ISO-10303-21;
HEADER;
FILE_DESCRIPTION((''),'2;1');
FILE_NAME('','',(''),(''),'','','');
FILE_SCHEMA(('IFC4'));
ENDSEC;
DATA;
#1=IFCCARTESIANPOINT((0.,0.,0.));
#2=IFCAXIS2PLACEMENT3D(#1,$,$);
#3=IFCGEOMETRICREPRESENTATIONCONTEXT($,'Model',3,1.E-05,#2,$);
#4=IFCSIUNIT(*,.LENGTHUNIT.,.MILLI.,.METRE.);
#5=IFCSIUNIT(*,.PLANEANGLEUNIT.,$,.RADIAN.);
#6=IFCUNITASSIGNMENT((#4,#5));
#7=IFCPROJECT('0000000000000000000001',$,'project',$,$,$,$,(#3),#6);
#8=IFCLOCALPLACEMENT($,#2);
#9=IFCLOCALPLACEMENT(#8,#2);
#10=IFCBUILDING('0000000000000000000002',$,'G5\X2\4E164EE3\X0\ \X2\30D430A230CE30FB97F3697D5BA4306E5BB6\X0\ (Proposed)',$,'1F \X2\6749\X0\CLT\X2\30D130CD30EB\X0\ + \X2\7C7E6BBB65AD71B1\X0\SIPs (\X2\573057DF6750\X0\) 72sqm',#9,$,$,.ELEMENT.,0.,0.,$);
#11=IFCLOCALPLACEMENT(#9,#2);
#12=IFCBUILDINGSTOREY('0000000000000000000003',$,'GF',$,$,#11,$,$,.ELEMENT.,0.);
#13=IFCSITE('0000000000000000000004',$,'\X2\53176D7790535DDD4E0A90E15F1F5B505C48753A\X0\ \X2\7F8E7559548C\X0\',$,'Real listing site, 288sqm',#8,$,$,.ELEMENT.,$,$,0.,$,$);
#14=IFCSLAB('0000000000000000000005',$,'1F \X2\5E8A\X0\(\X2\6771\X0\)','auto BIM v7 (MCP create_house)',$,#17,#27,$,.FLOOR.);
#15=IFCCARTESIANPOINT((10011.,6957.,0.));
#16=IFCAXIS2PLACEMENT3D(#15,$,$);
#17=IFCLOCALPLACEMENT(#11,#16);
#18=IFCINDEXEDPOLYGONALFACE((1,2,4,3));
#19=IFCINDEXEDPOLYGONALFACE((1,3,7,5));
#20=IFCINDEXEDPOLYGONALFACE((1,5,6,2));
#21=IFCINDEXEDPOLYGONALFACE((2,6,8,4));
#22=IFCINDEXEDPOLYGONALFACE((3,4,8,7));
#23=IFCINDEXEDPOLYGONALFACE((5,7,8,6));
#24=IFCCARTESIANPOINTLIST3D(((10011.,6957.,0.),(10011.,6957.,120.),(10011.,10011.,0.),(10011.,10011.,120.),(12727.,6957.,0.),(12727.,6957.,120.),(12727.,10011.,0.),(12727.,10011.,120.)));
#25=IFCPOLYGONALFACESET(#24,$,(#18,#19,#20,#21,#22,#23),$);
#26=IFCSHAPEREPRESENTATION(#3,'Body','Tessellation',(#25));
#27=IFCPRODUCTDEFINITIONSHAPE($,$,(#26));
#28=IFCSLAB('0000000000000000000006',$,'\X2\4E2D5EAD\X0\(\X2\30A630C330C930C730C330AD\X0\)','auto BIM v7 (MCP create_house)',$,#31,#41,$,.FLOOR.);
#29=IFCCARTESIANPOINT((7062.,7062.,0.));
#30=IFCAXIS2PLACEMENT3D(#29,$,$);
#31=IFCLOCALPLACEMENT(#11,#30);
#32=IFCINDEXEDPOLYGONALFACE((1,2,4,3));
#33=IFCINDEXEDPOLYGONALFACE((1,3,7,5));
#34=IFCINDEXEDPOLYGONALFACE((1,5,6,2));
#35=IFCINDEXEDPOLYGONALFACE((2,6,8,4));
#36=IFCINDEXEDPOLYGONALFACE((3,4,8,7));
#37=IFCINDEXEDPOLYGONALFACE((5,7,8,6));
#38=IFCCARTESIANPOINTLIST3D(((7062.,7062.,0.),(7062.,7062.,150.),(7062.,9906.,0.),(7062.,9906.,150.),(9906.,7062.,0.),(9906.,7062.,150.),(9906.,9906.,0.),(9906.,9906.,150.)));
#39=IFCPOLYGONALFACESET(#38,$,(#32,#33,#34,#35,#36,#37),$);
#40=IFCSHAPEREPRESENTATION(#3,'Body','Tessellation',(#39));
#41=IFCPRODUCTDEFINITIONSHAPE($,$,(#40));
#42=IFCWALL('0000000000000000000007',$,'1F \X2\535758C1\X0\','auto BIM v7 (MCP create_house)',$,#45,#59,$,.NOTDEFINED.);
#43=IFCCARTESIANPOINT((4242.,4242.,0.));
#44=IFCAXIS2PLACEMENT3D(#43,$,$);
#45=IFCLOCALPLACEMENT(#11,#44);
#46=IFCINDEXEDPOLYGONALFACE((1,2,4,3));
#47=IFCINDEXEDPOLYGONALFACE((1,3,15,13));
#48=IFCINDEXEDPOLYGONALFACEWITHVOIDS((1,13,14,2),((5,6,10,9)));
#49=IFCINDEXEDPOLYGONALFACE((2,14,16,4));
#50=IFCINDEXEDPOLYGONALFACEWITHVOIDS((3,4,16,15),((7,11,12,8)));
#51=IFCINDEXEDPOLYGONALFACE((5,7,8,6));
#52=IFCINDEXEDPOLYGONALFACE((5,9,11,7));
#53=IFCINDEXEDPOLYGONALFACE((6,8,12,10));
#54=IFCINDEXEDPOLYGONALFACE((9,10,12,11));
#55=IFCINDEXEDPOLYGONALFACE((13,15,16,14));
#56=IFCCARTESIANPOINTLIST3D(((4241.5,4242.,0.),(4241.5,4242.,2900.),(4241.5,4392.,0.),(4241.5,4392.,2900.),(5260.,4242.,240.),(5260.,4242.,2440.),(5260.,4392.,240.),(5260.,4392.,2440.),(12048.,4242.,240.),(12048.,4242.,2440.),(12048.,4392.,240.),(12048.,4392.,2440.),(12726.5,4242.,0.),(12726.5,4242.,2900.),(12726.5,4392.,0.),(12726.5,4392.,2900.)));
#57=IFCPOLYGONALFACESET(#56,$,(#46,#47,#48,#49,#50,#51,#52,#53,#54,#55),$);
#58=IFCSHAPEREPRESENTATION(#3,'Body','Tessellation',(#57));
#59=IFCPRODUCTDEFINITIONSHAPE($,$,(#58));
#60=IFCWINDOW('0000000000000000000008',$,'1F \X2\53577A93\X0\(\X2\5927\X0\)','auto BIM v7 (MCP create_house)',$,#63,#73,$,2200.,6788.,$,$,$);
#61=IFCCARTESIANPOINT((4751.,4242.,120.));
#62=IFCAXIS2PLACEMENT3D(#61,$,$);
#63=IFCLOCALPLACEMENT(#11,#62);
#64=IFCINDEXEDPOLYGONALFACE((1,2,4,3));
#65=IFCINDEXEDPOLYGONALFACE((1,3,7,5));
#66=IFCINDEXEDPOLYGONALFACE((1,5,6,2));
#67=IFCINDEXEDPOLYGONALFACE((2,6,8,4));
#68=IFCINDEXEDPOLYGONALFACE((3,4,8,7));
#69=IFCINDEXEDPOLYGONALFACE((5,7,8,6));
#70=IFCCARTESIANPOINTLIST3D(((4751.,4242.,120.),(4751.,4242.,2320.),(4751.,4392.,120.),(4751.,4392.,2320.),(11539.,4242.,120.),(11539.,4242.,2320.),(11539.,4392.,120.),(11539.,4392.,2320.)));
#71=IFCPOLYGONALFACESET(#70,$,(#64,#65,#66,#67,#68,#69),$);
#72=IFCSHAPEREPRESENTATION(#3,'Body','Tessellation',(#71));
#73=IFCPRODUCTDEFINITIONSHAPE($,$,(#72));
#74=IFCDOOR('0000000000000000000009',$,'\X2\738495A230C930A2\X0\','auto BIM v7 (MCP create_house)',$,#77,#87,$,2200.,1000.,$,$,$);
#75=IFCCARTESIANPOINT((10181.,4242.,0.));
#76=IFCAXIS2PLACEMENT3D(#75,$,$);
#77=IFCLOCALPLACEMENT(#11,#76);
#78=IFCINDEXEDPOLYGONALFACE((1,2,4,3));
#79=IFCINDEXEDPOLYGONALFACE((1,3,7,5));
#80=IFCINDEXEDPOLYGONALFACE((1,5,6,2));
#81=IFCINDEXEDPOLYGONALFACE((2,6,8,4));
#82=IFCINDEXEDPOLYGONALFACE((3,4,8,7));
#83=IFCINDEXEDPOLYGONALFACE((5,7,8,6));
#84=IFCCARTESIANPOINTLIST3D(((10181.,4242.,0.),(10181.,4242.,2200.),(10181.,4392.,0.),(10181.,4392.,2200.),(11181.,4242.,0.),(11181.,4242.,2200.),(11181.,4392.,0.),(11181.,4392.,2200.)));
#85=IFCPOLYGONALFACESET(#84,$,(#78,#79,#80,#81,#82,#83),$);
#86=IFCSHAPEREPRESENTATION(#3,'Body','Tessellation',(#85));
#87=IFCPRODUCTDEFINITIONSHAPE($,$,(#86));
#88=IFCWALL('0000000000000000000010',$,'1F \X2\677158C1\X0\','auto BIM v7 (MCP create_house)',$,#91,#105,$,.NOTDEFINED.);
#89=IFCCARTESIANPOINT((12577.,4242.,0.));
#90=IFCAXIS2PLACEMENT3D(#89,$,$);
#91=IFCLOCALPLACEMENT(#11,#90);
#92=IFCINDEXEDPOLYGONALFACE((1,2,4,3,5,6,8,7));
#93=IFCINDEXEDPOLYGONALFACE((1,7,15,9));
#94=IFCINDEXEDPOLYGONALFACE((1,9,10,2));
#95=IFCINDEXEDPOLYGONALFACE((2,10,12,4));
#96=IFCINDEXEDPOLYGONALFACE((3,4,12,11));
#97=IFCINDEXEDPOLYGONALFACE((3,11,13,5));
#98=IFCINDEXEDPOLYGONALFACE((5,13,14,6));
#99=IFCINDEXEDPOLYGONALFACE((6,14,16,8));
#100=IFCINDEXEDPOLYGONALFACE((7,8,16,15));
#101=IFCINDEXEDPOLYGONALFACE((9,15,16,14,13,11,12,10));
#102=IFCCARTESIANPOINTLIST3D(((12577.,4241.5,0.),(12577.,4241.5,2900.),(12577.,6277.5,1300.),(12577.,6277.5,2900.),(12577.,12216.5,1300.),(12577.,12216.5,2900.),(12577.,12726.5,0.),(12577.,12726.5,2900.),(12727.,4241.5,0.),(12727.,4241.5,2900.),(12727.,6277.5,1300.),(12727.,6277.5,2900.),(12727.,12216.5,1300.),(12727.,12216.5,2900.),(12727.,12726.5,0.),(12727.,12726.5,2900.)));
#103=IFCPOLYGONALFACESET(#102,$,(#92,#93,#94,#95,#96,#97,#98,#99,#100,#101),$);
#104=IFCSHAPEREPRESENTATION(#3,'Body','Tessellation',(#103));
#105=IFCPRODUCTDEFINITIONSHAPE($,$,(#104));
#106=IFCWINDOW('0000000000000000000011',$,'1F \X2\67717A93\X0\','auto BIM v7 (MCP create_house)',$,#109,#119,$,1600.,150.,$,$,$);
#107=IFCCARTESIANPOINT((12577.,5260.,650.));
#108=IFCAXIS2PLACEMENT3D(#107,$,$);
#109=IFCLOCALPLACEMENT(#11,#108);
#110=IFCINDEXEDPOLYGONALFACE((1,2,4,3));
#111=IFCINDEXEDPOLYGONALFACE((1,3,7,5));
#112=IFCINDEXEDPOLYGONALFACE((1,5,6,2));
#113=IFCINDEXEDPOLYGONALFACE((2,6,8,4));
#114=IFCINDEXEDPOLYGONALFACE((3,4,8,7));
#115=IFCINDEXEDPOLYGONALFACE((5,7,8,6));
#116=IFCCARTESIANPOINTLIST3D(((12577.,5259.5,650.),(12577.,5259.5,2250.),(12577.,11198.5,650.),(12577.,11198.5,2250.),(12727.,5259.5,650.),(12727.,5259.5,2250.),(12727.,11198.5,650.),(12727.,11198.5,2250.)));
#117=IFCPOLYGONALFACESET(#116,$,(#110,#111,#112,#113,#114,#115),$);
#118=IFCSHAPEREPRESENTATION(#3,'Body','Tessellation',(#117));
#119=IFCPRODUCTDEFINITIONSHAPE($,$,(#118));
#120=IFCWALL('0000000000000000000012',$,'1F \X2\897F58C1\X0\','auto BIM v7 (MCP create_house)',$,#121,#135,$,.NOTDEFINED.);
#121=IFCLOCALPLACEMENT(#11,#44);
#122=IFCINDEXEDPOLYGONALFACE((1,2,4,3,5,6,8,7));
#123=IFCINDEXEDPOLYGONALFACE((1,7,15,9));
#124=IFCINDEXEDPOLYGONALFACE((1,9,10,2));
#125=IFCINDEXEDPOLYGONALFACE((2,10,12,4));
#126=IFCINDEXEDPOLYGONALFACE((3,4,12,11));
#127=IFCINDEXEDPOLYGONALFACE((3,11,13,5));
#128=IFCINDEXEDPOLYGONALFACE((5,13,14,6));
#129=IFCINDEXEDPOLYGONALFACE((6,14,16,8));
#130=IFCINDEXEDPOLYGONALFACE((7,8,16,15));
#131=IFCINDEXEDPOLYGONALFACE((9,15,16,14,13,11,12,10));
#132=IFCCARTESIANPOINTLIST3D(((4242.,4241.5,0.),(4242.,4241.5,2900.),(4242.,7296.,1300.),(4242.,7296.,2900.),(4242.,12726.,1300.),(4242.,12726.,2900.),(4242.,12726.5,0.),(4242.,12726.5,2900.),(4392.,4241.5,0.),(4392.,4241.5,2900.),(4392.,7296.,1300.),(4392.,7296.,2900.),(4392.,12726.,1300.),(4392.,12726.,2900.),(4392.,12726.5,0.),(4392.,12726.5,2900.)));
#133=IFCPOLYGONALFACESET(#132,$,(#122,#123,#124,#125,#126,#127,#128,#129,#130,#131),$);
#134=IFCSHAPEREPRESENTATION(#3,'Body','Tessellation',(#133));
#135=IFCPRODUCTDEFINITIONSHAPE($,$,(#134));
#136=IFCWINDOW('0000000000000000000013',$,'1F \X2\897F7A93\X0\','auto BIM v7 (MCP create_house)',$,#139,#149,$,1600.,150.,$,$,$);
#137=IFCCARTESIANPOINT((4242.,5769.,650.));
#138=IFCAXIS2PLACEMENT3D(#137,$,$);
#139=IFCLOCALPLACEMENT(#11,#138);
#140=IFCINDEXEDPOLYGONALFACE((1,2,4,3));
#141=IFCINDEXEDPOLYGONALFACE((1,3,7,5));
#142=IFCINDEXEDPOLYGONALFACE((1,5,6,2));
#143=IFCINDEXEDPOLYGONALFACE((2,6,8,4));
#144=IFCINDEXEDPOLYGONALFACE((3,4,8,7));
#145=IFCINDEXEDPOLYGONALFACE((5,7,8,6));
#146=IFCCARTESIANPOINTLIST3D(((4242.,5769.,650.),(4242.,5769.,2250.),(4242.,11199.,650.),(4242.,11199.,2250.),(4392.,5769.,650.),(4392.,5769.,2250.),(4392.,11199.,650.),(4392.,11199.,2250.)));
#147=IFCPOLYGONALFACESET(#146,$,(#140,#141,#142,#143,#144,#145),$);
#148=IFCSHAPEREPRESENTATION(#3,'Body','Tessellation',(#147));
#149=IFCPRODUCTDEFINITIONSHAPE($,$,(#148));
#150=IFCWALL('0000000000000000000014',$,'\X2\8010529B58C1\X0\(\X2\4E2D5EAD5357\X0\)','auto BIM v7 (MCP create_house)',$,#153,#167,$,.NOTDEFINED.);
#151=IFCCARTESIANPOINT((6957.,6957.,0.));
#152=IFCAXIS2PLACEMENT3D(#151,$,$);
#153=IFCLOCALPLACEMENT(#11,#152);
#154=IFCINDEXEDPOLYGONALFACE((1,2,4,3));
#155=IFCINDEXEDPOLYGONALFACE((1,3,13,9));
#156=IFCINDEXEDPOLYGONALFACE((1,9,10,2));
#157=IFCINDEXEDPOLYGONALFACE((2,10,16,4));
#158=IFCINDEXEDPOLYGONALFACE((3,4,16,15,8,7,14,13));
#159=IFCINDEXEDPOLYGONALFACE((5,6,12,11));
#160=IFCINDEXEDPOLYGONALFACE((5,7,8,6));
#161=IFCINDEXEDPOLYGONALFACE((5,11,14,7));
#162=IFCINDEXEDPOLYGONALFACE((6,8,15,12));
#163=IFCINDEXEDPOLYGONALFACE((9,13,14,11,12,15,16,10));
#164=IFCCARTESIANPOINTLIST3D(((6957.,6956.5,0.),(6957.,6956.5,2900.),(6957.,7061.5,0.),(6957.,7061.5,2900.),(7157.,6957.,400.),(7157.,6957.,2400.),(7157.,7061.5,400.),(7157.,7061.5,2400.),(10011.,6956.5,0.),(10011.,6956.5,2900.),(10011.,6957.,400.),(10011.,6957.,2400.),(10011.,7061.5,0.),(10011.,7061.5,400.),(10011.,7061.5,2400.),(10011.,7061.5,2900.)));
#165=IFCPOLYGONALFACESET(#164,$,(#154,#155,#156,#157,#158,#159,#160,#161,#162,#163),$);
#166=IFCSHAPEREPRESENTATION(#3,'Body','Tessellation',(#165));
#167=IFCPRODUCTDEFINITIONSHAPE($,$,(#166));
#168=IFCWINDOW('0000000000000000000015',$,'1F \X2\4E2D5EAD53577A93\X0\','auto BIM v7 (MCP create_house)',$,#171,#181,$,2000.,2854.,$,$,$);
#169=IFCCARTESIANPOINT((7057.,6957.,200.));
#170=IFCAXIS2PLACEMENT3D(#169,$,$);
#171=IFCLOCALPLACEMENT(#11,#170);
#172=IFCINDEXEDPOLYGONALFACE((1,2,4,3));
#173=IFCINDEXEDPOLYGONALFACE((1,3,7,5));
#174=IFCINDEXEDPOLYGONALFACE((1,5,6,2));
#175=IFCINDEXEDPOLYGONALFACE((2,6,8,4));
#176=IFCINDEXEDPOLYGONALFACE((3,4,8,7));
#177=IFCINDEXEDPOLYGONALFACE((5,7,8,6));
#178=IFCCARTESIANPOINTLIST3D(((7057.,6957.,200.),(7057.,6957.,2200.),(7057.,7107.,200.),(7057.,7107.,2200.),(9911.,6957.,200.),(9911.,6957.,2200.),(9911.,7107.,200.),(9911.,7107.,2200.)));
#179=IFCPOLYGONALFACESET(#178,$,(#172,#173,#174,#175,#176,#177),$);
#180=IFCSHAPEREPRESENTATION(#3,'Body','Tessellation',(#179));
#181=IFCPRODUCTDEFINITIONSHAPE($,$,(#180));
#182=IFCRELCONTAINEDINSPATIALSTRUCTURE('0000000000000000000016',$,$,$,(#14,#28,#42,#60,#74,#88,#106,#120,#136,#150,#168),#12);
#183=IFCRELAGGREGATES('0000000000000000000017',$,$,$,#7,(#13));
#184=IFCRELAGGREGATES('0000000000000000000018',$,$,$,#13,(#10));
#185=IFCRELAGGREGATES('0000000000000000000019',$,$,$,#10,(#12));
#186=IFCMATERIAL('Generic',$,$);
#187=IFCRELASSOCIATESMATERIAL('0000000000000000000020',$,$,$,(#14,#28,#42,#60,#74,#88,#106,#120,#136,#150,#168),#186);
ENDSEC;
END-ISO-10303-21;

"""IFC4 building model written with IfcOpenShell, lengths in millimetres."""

from ifc_helpers import new_model, si_unit, frame, frame_2d, origin, place, context, project, spatial, rectangle, extrude, material, element, fill, save


model = new_model("IFC4")

# Units and contexts
model_context = context("Model", 3, precision=1e-05, world=origin())
ifc_project = project(units=[si_unit("LENGTHUNIT", "METRE", prefix="MILLI"), si_unit("PLANEANGLEUNIT", "RADIAN")], contexts=[model_context])

# Site, building, storey
site_placement = place(None, origin())
site = spatial("IfcSite", under=ifc_project, at=site_placement, Name="北海道川上郡弟子屈町 美留和", ObjectType="Real listing site, 288sqm", CompositionType="ELEMENT", RefElevation=0.0)
building_placement = place(site_placement, origin())
building = spatial("IfcBuilding", under=site, at=building_placement, Name="G5世代 ピアノ・音楽室の家 (Proposed)", ObjectType="1F 杉CLTパネル + 籾殻断熱SIPs (地域材) 72sqm", CompositionType="ELEMENT", ElevationOfRefHeight=0.0, ElevationOfTerrain=0.0)
storey_placement = place(building_placement, origin())
storey = spatial("IfcBuildingStorey", under=building, at=storey_placement, Name="GF", CompositionType="ELEMENT", Elevation=0.0)

# Slabs
ifc_material = material(Name="Generic")
slab_1_placement = place(storey_placement, frame((10011.0, 6957.0, 0.0)))
element("IfcSlab", 1, at=slab_1_placement, inside=storey, material=ifc_material, Name="1F 床(東)", Description="auto BIM v7 (MCP create_house)", PredefinedType="FLOOR", context=model_context, shape_type="SweptSolid", body=[
    extrude(rectangle(XDim=2716.0, YDim=3054.0, at=frame_2d((1358.0, 1527.0))), frame((10011.0, 6957.0, 0.0)), (0.0, 0.0, 1.0), 120.0),
])
slab_2_placement = place(storey_placement, frame((7062.0, 7062.0, 0.0)))
element("IfcSlab", 2, at=slab_2_placement, inside=storey, material=ifc_material, Name="中庭(ウッドデッキ)", Description="auto BIM v7 (MCP create_house)", PredefinedType="FLOOR", context=model_context, shape_type="SweptSolid", body=[
    extrude(rectangle(XDim=2844.0, YDim=2844.0, at=frame_2d((1422.0, 1422.0))), frame((7062.0, 7062.0, 0.0)), (0.0, 0.0, 1.0), 150.0),
])

# Wall, openings, window, door
wall_1_placement = place(storey_placement, frame((4242.0, 4242.0, 0.0)))
wall_1 = element("IfcWall", 3, at=wall_1_placement, inside=storey, material=ifc_material, Name="1F 南壁", Description="auto BIM v7 (MCP create_house)", PredefinedType="NOTDEFINED", context=model_context, shape_type="SweptSolid", body=[
    extrude(rectangle(XDim=8485.0, YDim=150.0, at=frame_2d((4242.0, 75.0))), frame((4242.0, 4242.0, 0.0)), (0.0, 0.0, 1.0), 2900.0),
])
opening_1_placement = place(storey_placement, frame((4751.0, 4242.0, 120.0)))
opening_1 = element("IfcOpeningElement", 4, at=opening_1_placement, cuts=wall_1, PredefinedType="NOTDEFINED", context=model_context, shape_type="SweptSolid", body=[
    extrude(rectangle(XDim=6788.0, YDim=150.0, at=frame_2d((3394.0, 75.0))), frame((4751.0, 4242.0, 120.0)), (0.0, 0.0, 1.0), 2200.0),
])
opening_2_placement = place(storey_placement, frame((10181.0, 4242.0, 0.0)))
opening_2 = element("IfcOpeningElement", 5, at=opening_2_placement, cuts=wall_1, PredefinedType="NOTDEFINED", context=model_context, shape_type="SweptSolid", body=[
    extrude(rectangle(XDim=1000.0, YDim=150.0, at=frame_2d((500.0, 75.0))), frame((10181.0, 4242.0, 0.0)), (0.0, 0.0, 1.0), 2200.0),
])
window_1_placement = place(storey_placement, frame((4751.0, 4242.0, 120.0)))
window_1 = element("IfcWindow", 6, at=window_1_placement, inside=storey, material=ifc_material, Name="1F 南窓(大)", Description="auto BIM v7 (MCP create_house)", OverallHeight=2200.0, OverallWidth=6788.0, context=model_context, shape_type="SweptSolid", body=[
    extrude(rectangle(XDim=6788.0, YDim=150.0, at=frame_2d((3394.0, 75.0))), frame((4751.0, 4242.0, 120.0)), (0.0, 0.0, 1.0), 2200.0),
])
fill(opening_1, window_1)
door_placement = place(storey_placement, frame((10181.0, 4242.0, 0.0)))
door = element("IfcDoor", 7, at=door_placement, inside=storey, material=ifc_material, Name="玄関ドア", Description="auto BIM v7 (MCP create_house)", OverallHeight=2200.0, OverallWidth=1000.0, context=model_context, shape_type="SweptSolid", body=[
    extrude(rectangle(XDim=1000.0, YDim=150.0, at=frame_2d((500.0, 75.0))), frame((10181.0, 4242.0, 0.0)), (0.0, 0.0, 1.0), 2200.0),
])
fill(opening_2, door)

# Walls, openings, windows
wall_2_placement = place(storey_placement, frame((12577.0, 4242.0, 0.0)))
wall_2 = element("IfcWall", 8, at=wall_2_placement, inside=storey, material=ifc_material, Name="1F 東壁", Description="auto BIM v7 (MCP create_house)", PredefinedType="NOTDEFINED", context=model_context, shape_type="SweptSolid", body=[
    extrude(rectangle(XDim=150.0, YDim=8485.0, at=frame_2d((75.0, 4242.0))), frame((12577.0, 4242.0, 0.0)), (0.0, 0.0, 1.0), 2900.0),
])
opening_3_placement = place(storey_placement, frame((12577.0, 5260.0, 650.0)))
opening_3 = element("IfcOpeningElement", 9, at=opening_3_placement, cuts=wall_2, PredefinedType="NOTDEFINED", context=model_context, shape_type="SweptSolid", body=[
    extrude(rectangle(XDim=150.0, YDim=5939.0, at=frame_2d((75.0, 2969.0))), frame((12577.0, 5260.0, 650.0)), (0.0, 0.0, 1.0), 1600.0),
])
window_2_placement = place(storey_placement, frame((12577.0, 5260.0, 650.0)))
window_2 = element("IfcWindow", 10, at=window_2_placement, inside=storey, material=ifc_material, Name="1F 東窓", Description="auto BIM v7 (MCP create_house)", OverallHeight=1600.0, OverallWidth=150.0, context=model_context, shape_type="SweptSolid", body=[
    extrude(rectangle(XDim=150.0, YDim=5939.0, at=frame_2d((75.0, 2969.0))), frame((12577.0, 5260.0, 650.0)), (0.0, 0.0, 1.0), 1600.0),
])
fill(opening_3, window_2)
wall_3_placement = place(storey_placement, frame((4242.0, 4242.0, 0.0)))
wall_3 = element("IfcWall", 11, at=wall_3_placement, inside=storey, material=ifc_material, Name="1F 西壁", Description="auto BIM v7 (MCP create_house)", PredefinedType="NOTDEFINED", context=model_context, shape_type="SweptSolid", body=[
    extrude(rectangle(XDim=150.0, YDim=8485.0, at=frame_2d((75.0, 4242.0))), frame((4242.0, 4242.0, 0.0)), (0.0, 0.0, 1.0), 2900.0),
])
opening_4_placement = place(storey_placement, frame((4242.0, 5769.0, 650.0)))
opening_4 = element("IfcOpeningElement", 12, at=opening_4_placement, cuts=wall_3, PredefinedType="NOTDEFINED", context=model_context, shape_type="SweptSolid", body=[
    extrude(rectangle(XDim=150.0, YDim=5430.0, at=frame_2d((75.0, 2715.0))), frame((4242.0, 5769.0, 650.0)), (0.0, 0.0, 1.0), 1600.0),
])
window_3_placement = place(storey_placement, frame((4242.0, 5769.0, 650.0)))
window_3 = element("IfcWindow", 13, at=window_3_placement, inside=storey, material=ifc_material, Name="1F 西窓", Description="auto BIM v7 (MCP create_house)", OverallHeight=1600.0, OverallWidth=150.0, context=model_context, shape_type="SweptSolid", body=[
    extrude(rectangle(XDim=150.0, YDim=5430.0, at=frame_2d((75.0, 2715.0))), frame((4242.0, 5769.0, 650.0)), (0.0, 0.0, 1.0), 1600.0),
])
fill(opening_4, window_3)
wall_4_placement = place(storey_placement, frame((6957.0, 6957.0, 0.0)))
wall_4 = element("IfcWall", 14, at=wall_4_placement, inside=storey, material=ifc_material, Name="耐力壁(中庭南)", Description="auto BIM v7 (MCP create_house)", PredefinedType="NOTDEFINED", context=model_context, shape_type="SweptSolid", body=[
    extrude(rectangle(XDim=3054.0, YDim=105.0, at=frame_2d((1527.0, 52.0))), frame((6957.0, 6957.0, 0.0)), (0.0, 0.0, 1.0), 2900.0),
])
opening_5_placement = place(storey_placement, frame((7057.0, 6957.0, 200.0)))
opening_5 = element("IfcOpeningElement", 15, at=opening_5_placement, cuts=wall_4, PredefinedType="NOTDEFINED", context=model_context, shape_type="SweptSolid", body=[
    extrude(rectangle(XDim=2854.0, YDim=150.0, at=frame_2d((1427.0, 75.0))), frame((7057.0, 6957.0, 200.0)), (0.0, 0.0, 1.0), 2000.0),
])
window_4_placement = place(storey_placement, frame((7057.0, 6957.0, 200.0)))
window_4 = element("IfcWindow", 16, at=window_4_placement, inside=storey, material=ifc_material, Name="1F 中庭南窓", Description="auto BIM v7 (MCP create_house)", OverallHeight=2000.0, OverallWidth=2854.0, context=model_context, shape_type="SweptSolid", body=[
    extrude(rectangle(XDim=2854.0, YDim=150.0, at=frame_2d((1427.0, 75.0))), frame((7057.0, 6957.0, 200.0)), (0.0, 0.0, 1.0), 2000.0),
])
fill(opening_5, window_4)

save(model, "model.ifc")
